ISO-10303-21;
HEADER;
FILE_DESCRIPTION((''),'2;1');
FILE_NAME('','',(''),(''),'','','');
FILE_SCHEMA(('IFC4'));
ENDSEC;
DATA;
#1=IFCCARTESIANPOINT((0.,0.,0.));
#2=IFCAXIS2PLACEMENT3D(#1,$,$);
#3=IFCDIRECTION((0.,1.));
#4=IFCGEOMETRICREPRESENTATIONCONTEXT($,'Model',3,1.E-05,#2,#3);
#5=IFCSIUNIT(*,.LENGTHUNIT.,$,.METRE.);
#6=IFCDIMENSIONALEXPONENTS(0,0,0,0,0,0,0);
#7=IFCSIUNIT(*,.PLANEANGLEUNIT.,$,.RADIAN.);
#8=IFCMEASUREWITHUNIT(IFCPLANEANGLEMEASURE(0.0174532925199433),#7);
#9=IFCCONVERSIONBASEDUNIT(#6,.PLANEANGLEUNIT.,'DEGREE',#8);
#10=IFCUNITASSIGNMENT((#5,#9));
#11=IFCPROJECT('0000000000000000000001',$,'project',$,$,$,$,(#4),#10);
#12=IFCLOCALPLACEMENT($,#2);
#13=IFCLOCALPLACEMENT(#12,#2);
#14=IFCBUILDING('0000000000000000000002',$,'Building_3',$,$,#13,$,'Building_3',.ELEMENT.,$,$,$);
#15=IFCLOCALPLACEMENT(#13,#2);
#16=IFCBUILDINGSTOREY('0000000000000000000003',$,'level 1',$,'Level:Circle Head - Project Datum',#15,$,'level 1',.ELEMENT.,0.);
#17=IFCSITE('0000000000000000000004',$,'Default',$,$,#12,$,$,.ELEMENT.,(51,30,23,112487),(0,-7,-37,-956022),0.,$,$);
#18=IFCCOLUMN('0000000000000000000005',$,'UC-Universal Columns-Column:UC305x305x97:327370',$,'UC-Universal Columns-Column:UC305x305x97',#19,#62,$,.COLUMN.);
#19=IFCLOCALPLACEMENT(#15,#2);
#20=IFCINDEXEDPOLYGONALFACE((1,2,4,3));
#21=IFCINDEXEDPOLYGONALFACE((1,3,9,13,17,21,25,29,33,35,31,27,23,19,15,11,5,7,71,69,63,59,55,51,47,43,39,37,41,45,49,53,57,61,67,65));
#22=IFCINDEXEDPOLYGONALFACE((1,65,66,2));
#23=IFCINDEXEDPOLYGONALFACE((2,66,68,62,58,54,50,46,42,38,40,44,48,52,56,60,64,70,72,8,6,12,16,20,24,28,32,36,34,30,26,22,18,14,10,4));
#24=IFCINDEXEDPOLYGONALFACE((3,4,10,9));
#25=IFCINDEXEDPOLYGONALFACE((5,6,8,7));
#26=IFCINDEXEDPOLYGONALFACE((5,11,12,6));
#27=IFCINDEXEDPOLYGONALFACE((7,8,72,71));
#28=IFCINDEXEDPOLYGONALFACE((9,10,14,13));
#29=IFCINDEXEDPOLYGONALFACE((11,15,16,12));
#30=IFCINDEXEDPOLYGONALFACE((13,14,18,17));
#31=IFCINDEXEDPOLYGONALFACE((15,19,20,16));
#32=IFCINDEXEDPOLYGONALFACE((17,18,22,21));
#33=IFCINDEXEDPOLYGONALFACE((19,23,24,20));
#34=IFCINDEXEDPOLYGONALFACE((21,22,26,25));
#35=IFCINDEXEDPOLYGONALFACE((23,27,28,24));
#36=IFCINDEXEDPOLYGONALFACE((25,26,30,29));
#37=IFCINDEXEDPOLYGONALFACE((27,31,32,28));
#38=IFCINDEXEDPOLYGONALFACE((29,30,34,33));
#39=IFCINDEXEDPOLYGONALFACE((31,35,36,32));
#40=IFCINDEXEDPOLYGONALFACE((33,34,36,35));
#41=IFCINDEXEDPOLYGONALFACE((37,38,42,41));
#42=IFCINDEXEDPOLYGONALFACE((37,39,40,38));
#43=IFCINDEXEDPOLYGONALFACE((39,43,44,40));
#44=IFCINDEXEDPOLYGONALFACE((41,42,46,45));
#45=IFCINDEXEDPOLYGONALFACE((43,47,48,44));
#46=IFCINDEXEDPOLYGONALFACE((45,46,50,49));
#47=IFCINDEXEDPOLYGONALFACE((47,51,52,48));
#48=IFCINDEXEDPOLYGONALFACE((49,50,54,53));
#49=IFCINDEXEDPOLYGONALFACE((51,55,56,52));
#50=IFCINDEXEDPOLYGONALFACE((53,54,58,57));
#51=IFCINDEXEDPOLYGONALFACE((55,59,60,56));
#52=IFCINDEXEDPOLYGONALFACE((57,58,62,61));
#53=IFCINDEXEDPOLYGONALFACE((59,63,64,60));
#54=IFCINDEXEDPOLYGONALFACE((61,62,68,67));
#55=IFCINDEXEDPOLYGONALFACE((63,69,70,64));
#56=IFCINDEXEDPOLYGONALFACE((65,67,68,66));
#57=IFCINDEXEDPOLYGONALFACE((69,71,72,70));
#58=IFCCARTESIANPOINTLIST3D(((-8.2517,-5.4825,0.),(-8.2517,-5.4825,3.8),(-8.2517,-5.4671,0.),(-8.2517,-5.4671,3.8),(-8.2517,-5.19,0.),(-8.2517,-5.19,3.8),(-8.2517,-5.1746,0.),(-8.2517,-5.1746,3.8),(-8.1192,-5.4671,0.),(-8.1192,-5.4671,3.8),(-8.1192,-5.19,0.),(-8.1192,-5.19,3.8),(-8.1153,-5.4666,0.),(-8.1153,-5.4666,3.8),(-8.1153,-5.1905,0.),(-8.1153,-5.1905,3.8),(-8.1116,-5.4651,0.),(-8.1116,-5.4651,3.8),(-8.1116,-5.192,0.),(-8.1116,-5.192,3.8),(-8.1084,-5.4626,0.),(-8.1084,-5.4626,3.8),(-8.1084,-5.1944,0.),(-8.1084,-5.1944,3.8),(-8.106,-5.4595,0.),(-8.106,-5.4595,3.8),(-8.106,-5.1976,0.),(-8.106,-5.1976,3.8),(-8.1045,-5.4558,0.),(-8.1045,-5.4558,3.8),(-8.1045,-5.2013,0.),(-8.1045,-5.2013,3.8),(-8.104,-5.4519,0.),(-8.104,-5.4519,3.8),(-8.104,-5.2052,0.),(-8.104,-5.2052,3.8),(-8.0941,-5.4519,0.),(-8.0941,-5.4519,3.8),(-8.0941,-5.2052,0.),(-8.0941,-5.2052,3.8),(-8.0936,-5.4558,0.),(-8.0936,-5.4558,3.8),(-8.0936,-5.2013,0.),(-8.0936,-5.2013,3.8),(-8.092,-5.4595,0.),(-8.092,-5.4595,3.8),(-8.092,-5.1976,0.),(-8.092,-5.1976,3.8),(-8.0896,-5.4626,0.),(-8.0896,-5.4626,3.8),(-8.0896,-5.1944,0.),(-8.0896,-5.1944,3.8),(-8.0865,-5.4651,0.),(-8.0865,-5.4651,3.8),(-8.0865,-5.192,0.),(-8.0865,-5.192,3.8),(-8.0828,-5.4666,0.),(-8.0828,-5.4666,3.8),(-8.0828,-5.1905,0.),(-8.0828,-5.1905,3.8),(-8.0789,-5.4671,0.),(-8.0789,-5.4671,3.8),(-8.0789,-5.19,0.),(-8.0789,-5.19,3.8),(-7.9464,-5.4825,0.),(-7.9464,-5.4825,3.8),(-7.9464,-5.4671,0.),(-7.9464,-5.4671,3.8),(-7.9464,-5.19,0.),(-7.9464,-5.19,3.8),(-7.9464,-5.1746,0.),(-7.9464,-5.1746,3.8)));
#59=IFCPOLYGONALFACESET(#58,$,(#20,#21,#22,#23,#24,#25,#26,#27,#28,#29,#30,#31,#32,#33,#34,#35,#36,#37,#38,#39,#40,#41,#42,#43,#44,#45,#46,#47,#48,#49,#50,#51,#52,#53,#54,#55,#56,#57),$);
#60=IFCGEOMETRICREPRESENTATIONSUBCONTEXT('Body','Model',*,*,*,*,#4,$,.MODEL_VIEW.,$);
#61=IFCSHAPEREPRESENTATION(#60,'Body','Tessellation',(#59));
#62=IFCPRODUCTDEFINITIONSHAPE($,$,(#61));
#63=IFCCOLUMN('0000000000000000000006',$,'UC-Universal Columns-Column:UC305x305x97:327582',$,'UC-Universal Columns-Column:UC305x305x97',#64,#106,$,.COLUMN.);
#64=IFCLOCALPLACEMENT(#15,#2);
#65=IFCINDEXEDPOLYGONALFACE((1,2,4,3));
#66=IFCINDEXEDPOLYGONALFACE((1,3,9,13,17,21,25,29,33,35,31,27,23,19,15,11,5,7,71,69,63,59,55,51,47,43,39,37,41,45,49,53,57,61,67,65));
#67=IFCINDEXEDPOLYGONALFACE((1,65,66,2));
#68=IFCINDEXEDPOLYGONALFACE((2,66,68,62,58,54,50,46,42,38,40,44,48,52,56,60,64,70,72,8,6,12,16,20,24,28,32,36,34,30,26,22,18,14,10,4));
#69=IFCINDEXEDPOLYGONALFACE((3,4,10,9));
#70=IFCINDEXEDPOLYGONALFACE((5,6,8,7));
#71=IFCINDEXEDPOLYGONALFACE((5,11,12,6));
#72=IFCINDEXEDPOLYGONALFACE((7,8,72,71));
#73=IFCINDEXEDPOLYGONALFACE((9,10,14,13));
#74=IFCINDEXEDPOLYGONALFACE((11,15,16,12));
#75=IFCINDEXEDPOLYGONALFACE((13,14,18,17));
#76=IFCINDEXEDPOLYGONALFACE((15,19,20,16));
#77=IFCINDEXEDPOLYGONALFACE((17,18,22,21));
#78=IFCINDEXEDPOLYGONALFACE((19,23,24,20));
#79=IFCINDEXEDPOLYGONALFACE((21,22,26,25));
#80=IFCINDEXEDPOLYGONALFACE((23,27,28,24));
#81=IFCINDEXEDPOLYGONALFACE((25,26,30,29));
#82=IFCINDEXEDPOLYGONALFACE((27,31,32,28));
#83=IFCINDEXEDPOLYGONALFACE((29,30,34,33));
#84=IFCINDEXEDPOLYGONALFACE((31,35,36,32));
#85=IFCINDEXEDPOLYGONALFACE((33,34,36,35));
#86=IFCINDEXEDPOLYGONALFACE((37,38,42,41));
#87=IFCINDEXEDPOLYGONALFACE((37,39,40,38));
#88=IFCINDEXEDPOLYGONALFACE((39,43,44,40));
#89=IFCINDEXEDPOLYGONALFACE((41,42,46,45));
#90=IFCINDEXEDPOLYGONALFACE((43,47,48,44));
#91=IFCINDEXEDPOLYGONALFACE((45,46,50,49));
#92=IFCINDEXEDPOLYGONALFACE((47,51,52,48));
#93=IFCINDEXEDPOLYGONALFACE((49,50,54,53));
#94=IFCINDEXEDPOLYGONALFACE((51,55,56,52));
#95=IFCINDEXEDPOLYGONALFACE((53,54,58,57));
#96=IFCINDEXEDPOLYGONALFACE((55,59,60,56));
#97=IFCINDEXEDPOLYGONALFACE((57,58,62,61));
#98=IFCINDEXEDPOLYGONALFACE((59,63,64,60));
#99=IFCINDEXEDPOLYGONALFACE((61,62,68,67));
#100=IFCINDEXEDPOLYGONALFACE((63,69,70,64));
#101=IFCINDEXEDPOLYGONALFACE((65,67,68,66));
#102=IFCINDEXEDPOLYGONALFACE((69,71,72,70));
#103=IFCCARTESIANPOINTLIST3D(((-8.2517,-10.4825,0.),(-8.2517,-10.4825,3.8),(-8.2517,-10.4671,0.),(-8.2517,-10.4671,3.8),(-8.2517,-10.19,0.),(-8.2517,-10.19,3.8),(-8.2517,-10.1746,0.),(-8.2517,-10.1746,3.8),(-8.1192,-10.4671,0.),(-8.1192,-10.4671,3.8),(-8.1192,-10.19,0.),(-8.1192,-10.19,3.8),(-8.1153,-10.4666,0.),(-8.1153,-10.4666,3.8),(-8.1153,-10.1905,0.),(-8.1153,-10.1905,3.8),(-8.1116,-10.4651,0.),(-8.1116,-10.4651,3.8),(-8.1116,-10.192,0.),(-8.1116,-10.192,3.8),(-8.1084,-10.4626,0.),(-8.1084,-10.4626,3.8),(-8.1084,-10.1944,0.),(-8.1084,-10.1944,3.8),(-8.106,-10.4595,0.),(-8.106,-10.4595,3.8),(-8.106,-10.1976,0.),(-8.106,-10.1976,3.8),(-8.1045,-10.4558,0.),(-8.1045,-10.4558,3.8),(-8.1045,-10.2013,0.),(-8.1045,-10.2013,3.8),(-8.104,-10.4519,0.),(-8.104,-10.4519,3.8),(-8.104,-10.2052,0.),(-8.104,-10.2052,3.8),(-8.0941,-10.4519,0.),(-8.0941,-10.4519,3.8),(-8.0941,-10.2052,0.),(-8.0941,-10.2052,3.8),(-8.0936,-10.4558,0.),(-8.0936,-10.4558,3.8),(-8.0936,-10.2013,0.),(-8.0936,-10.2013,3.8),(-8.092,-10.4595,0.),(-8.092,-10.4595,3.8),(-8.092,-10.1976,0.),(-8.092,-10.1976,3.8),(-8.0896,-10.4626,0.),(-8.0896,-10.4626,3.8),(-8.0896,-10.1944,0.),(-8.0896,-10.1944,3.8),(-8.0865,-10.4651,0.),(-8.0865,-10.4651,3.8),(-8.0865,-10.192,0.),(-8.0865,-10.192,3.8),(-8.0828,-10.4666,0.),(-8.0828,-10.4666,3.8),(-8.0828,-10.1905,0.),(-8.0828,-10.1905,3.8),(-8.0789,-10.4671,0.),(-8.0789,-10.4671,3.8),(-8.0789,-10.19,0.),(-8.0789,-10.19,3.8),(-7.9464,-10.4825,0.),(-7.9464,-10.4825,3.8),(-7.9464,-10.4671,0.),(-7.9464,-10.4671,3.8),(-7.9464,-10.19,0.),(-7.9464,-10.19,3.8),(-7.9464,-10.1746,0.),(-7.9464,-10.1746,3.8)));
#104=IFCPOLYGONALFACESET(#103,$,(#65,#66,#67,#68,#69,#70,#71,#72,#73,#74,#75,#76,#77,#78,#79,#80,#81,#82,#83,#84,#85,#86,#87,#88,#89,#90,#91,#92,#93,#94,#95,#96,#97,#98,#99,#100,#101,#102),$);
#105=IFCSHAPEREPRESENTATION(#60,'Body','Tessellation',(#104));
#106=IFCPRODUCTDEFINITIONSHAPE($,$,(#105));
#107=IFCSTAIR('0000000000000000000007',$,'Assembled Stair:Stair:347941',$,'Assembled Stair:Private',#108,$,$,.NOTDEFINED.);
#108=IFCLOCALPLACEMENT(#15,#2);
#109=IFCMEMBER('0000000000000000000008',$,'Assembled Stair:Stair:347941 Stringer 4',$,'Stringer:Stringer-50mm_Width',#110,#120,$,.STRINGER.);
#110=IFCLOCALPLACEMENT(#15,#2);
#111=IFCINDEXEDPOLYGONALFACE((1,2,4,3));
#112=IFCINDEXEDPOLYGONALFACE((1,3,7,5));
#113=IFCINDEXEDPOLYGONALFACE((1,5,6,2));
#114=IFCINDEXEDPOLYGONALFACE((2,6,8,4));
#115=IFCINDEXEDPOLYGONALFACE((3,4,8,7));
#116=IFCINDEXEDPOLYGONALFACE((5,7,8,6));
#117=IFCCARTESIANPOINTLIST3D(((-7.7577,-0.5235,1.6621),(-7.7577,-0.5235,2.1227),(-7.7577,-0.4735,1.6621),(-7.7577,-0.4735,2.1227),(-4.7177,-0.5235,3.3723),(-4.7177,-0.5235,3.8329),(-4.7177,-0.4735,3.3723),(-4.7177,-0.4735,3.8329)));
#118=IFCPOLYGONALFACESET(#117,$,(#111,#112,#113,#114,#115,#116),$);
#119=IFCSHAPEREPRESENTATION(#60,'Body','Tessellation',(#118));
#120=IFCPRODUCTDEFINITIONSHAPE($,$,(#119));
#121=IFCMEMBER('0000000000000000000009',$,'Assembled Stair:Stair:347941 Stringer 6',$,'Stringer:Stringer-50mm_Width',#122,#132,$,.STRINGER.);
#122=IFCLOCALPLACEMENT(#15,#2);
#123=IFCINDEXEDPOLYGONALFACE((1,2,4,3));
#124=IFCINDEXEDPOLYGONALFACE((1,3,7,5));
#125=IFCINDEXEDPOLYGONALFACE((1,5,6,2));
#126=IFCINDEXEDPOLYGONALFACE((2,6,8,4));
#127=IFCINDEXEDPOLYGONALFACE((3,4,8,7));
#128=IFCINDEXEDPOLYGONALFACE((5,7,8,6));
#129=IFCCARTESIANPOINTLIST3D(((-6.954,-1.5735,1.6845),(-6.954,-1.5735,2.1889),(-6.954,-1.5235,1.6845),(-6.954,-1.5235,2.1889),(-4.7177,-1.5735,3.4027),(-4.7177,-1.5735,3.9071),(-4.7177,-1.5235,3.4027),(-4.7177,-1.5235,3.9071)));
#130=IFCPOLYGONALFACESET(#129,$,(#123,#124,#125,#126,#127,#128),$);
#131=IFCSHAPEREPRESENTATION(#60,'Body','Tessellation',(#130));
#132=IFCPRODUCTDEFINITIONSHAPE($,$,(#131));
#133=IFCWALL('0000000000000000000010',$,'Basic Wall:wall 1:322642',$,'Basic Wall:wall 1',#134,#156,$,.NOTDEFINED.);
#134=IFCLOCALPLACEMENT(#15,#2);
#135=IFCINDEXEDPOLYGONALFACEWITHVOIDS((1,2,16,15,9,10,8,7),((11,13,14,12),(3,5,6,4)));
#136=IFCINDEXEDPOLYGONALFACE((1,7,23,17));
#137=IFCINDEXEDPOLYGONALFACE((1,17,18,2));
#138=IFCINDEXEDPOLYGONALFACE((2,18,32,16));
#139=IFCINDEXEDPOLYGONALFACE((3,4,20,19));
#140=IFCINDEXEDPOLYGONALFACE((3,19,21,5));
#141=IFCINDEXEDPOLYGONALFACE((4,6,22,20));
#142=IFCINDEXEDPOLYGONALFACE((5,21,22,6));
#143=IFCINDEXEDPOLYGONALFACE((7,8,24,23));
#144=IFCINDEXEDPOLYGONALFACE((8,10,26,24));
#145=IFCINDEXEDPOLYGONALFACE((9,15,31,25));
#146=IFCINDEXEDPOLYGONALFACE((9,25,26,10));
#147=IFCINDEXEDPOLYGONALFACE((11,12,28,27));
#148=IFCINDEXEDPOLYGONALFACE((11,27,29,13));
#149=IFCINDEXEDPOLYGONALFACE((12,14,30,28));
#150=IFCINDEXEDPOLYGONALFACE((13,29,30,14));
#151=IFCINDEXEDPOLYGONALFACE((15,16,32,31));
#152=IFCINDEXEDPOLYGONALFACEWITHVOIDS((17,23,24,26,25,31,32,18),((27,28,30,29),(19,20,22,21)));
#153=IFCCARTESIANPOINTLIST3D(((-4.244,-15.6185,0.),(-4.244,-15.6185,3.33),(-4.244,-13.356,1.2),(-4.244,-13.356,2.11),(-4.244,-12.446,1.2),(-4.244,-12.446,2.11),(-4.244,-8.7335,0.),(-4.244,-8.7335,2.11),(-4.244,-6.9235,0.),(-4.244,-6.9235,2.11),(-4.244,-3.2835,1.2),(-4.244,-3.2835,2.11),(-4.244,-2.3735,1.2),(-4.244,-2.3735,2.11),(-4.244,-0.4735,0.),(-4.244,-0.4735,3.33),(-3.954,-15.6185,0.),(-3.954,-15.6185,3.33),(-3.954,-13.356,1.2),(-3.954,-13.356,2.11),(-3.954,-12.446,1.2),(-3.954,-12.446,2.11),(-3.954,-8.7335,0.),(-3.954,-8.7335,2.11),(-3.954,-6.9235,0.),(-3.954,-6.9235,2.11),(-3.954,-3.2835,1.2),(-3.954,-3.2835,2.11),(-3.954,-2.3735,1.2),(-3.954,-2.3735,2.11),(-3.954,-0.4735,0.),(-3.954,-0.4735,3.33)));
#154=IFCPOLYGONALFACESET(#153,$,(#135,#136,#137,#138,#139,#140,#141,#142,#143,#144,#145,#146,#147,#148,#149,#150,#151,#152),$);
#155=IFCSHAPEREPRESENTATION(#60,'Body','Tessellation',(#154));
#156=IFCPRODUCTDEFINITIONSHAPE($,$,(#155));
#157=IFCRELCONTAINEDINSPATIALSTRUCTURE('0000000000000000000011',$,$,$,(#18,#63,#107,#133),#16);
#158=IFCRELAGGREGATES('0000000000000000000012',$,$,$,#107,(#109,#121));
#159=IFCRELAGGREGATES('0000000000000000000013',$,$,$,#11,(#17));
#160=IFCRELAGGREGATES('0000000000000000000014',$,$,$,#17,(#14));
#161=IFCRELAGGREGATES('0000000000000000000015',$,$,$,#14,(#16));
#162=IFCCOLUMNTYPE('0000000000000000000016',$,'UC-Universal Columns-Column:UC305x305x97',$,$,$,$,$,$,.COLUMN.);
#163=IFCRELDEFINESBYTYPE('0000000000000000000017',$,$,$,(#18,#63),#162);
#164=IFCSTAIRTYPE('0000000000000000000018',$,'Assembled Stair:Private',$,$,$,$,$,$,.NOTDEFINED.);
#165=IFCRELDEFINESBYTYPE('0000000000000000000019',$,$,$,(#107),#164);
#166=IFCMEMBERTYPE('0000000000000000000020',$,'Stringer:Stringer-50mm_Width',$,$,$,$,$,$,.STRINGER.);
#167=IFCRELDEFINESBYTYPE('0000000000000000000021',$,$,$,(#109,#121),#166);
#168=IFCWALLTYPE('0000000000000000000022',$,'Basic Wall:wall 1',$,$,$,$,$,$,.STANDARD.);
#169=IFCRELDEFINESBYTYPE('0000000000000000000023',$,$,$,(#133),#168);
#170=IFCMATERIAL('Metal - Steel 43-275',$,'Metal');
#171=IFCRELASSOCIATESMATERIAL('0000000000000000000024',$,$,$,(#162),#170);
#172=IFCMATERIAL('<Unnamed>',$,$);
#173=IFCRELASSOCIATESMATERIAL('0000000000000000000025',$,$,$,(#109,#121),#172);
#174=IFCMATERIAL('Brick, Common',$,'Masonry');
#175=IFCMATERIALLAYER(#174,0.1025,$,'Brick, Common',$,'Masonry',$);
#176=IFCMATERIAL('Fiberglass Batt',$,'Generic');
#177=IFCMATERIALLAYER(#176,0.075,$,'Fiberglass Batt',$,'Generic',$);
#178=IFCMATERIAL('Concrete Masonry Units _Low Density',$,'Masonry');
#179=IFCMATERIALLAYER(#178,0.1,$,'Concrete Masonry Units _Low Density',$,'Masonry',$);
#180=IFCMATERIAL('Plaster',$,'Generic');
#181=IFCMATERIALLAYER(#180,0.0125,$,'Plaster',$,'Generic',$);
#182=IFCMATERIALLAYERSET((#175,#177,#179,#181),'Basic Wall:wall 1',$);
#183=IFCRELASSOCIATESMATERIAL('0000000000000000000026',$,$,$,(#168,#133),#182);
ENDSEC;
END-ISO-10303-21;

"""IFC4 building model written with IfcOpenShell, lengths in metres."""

from ifc_helpers import new_model, entity, si_unit, converted_unit, direction, frame, frame_2d, origin, origin_2d_with_axis, place, context, subcontext, project, spatial, polyline, rectangle, i_section, outline, extrude, clip, bounded_halfspace, source, transform, mapped, material, layer, layer_set, layer_usage, material_profile, profile_set, type_object, type_shapes, element, aggregate, save


model = new_model("IFC4")

# Units and contexts
model_context = context("Model", 3, precision=1e-05, world=origin(), true_north=direction((0.0, 1.0)))
body_context = subcontext(model_context, "Body", "Model", "MODEL_VIEW")
ifc_project = project(units=[si_unit("LENGTHUNIT", "METRE"), converted_unit("PLANEANGLEUNIT", "DEGREE", entity("IfcPlaneAngleMeasure", 0.0174532925199433), si_unit("PLANEANGLEUNIT", "RADIAN"), dimensions=[0, 0, 0, 0, 0, 0, 0])], contexts=[model_context])

# Site, building, storey
site_placement = place(None, origin())
site = spatial("IfcSite", under=ifc_project, at=site_placement, Name="Default", CompositionType="ELEMENT", RefLatitude=(51, 30, 23, 112487), RefLongitude=(0, -7, -37, -956022), RefElevation=0.0)
building_placement = place(site_placement, origin())
building = spatial("IfcBuilding", under=site, at=building_placement, Name="Building_3", LongName="Building_3", CompositionType="ELEMENT")
storey_placement = place(building_placement, origin())
storey = spatial("IfcBuildingStorey", under=building, at=storey_placement, Name="level 1", ObjectType="Level:Circle Head - Project Datum", LongName="level 1", CompositionType="ELEMENT", Elevation=0.0)

# Columns
ifc_material_1 = material(Name="Metal - Steel 43-275", Category="Metal")
ifc_material_profile = material_profile(ifc_material_1, i_section(OverallWidth=0.3053, OverallDepth=0.3079, WebThickness=0.0099, FlangeThickness=0.0154, FilletRadius=0.0152, at=frame_2d((0.0, 0.0), x_axis=(1.0, 0.0))), Name="UC305x305x97")
ifc_profile_set = profile_set([ifc_material_profile], Name="UC305x305x97")
column_type = type_object("IfcColumnType", Name="UC-Universal Columns-Column:UC305x305x97", PredefinedType="COLUMN", material=ifc_profile_set)
shared_shape = source(origin(), body_context, "Body", "SweptSolid", [
    extrude(i_section(OverallWidth=0.3053, OverallDepth=0.3079, WebThickness=0.0099, FlangeThickness=0.0154, FilletRadius=0.0152, at=origin_2d_with_axis()), frame((0.0, 0.0, 0.0), z_axis=(0.0, 0.0, 1.0), x_axis=(-1.0, 0.0, 0.0)), (0.0, 0.0, 1.0), 3.8),
])
type_shapes(column_type, [shared_shape])
for number, where, name in (
    (1, (-8.099, -5.3285, 0.0), "UC-Universal Columns-Column:UC305x305x97:327370"),
    (2, (-8.099, -10.3285, 0.0), "UC-Universal Columns-Column:UC305x305x97:327582"),
):
    element("IfcColumn", number, at=place(storey_placement, frame(where)), inside=storey, type_object=column_type, Name=name, ObjectType="UC-Universal Columns-Column:UC305x305x97", PredefinedType="COLUMN", context=body_context, shape_type="MappedRepresentation", body=[
        mapped(shared_shape, transform((0.0, 0.0, 0.0), scale=1.0)),
    ])

# Stair, members
stair_type = type_object("IfcStairType", Name="Assembled Stair:Private", PredefinedType="NOTDEFINED")
stair_placement = place(storey_placement, origin())
stair = element("IfcStair", 3, at=stair_placement, inside=storey, type_object=stair_type, Name="Assembled Stair:Stair:347941", ObjectType="Assembled Stair:Private", PredefinedType="NOTDEFINED")
ifc_material_2 = material(Name="<Unnamed>")
member_type = type_object("IfcMemberType", Name="Stringer:Stringer-50mm_Width", PredefinedType="STRINGER")
member_1_placement = place(stair_placement, frame((-7.7577, -0.5235, 1.6621)))
member_1 = element("IfcMember", 4, at=member_1_placement, type_object=member_type, material=ifc_material_2, Name="Assembled Stair:Stair:347941 Stringer 4", ObjectType="Stringer:Stringer-50mm_Width", PredefinedType="STRINGER", context=body_context, shape_type="SweptSolid", body=[
    extrude(outline(polyline([(-1.6311, -0.2007), (1.857, -0.2007), (1.6311, 0.2007), (-1.857, 0.2007), (-1.6311, -0.2007)])), frame((1.52, 0.0, 1.0854), z_axis=(0.0, 1.0, 0.0), x_axis=(0.871553, 0.0, 0.490302)), (0.0, 0.0, 1.0), 0.05),
])
member_2_placement = place(stair_placement, frame((-6.954, -1.5735, 1.6845)))
member_2 = element("IfcMember", 5, at=member_2_placement, type_object=member_type, material=ifc_material_2, Name="Assembled Stair:Stair:347941 Stringer 6", ObjectType="Stringer:Stringer-50mm_Width", PredefinedType="STRINGER", context=body_context, shape_type="SweptSolid", body=[
    extrude(outline(polyline([(-1.2564, -0.2), (1.5637, -0.2), (1.2564, 0.2), (-1.5637, 0.2), (-1.2564, -0.2)])), frame((1.1182, 0.0, 1.1113), z_axis=(0.0, 1.0, 0.0), x_axis=(0.792984, 0.0, 0.609242)), (0.0, 0.0, 1.0), 0.05),
])
aggregate(stair, [member_1, member_2])

# Wall, openings
ifc_material_3 = material(Name="Brick, Common", Category="Masonry")
ifc_layer_1 = layer(ifc_material_3, 0.1025, Name="Brick, Common", Category="Masonry")
ifc_material_4 = material(Name="Fiberglass Batt", Category="Generic")
ifc_layer_2 = layer(ifc_material_4, 0.075, Name="Fiberglass Batt", Category="Generic")
ifc_material_5 = material(Name="Concrete Masonry Units _Low Density", Category="Masonry")
ifc_layer_3 = layer(ifc_material_5, 0.1, Name="Concrete Masonry Units _Low Density", Category="Masonry")
ifc_material_6 = material(Name="Plaster", Category="Generic")
ifc_layer_4 = layer(ifc_material_6, 0.0125, Name="Plaster", Category="Generic")
ifc_layer_set_1 = layer_set([ifc_layer_1, ifc_layer_2, ifc_layer_3, ifc_layer_4], Name="Basic Wall:wall 1")
ifc_layer_usage_1 = layer_usage(ifc_layer_set_1, "AXIS2", "NEGATIVE", 0.145)
wall_type_1 = type_object("IfcWallType", Name="Basic Wall:wall 1", PredefinedType="STANDARD", material=ifc_layer_set_1)
wall_1_placement = place(storey_placement, frame((-4.099, -0.4735, 0.0), z_axis=(0.0, 0.0, 1.0), x_axis=(0.0, -1.0, 0.0)))
wall_1 = element("IfcWall", 6, at=wall_1_placement, inside=storey, type_object=wall_type_1, material=ifc_layer_usage_1, Name="Basic Wall:wall 1:322642", ObjectType="Basic Wall:wall 1", PredefinedType="NOTDEFINED", context=body_context, shape_type="Clipping", body=[
    clip(extrude(rectangle(XDim=15.145, YDim=0.29, at=frame_2d((7.5725, 0.0), x_axis=(-1.0, 0.0))), origin(), (0.0, 0.0, 1.0), 3.33), bounded_halfspace(frame((0.0, -0.145, 3.33), z_axis=(0.0, 0.0, -1.0), x_axis=(-1.0, 0.0, 0.0)), True, frame((0.0, -0.145, 3.33)), polyline([(0.0, 0.0), (4.7925, 0.0), (4.9175, 0.0), (9.7925, 0.0), (9.9175, 0.0), (14.855, 0.0), (15.145, 0.0), (15.145, 0.29), (0.0, 0.29), (0.0, 0.2806), (0.0, 0.0)]))),
])
opening_1_placement = place(wall_1_placement, frame((8.26, 0.145, 0.0)))
element("IfcOpeningElement", 7, at=opening_1_placement, cuts=wall_1, PredefinedType="OPENING", context=body_context, shape_type="SweptSolid", body=[
    extrude(rectangle(XDim=2.11, YDim=1.81, at=frame_2d((1.055, 0.905), x_axis=(-1.0, 0.0))), frame((0.0, 0.0, 0.0), z_axis=(0.0, -1.0, 0.0), x_axis=(0.0, 0.0, 1.0)), (0.0, 0.0, 1.0), 0.29),
])
opening_2_placement = place(wall_1_placement, frame((11.9725, -0.145, 1.2)))
element("IfcOpeningElement", 8, at=opening_2_placement, cuts=wall_1, PredefinedType="OPENING", context=body_context, shape_type="SweptSolid", body=[
    extrude(rectangle(XDim=0.91, YDim=0.91, at=frame_2d((0.455, 0.455), x_axis=(-1.0, 0.0))), frame((0.0, 0.0, 0.0), z_axis=(0.0, 1.0, 0.0), x_axis=(0.0, 0.0, 1.0)), (0.0, 0.0, 1.0), 0.29),
])
opening_3_placement = place(wall_1_placement, frame((1.9, -0.145, 1.2)))
element("IfcOpeningElement", 9, at=opening_3_placement, cuts=wall_1, PredefinedType="OPENING", context=body_context, shape_type="SweptSolid", body=[
    extrude(rectangle(XDim=0.91, YDim=0.91, at=frame_2d((0.455, 0.455), x_axis=(-1.0, 0.0))), frame((0.0, 0.0, 0.0), z_axis=(0.0, 1.0, 0.0), x_axis=(0.0, 0.0, 1.0)), (0.0, 0.0, 1.0), 0.29),
])

save(model, "model.ifc")
